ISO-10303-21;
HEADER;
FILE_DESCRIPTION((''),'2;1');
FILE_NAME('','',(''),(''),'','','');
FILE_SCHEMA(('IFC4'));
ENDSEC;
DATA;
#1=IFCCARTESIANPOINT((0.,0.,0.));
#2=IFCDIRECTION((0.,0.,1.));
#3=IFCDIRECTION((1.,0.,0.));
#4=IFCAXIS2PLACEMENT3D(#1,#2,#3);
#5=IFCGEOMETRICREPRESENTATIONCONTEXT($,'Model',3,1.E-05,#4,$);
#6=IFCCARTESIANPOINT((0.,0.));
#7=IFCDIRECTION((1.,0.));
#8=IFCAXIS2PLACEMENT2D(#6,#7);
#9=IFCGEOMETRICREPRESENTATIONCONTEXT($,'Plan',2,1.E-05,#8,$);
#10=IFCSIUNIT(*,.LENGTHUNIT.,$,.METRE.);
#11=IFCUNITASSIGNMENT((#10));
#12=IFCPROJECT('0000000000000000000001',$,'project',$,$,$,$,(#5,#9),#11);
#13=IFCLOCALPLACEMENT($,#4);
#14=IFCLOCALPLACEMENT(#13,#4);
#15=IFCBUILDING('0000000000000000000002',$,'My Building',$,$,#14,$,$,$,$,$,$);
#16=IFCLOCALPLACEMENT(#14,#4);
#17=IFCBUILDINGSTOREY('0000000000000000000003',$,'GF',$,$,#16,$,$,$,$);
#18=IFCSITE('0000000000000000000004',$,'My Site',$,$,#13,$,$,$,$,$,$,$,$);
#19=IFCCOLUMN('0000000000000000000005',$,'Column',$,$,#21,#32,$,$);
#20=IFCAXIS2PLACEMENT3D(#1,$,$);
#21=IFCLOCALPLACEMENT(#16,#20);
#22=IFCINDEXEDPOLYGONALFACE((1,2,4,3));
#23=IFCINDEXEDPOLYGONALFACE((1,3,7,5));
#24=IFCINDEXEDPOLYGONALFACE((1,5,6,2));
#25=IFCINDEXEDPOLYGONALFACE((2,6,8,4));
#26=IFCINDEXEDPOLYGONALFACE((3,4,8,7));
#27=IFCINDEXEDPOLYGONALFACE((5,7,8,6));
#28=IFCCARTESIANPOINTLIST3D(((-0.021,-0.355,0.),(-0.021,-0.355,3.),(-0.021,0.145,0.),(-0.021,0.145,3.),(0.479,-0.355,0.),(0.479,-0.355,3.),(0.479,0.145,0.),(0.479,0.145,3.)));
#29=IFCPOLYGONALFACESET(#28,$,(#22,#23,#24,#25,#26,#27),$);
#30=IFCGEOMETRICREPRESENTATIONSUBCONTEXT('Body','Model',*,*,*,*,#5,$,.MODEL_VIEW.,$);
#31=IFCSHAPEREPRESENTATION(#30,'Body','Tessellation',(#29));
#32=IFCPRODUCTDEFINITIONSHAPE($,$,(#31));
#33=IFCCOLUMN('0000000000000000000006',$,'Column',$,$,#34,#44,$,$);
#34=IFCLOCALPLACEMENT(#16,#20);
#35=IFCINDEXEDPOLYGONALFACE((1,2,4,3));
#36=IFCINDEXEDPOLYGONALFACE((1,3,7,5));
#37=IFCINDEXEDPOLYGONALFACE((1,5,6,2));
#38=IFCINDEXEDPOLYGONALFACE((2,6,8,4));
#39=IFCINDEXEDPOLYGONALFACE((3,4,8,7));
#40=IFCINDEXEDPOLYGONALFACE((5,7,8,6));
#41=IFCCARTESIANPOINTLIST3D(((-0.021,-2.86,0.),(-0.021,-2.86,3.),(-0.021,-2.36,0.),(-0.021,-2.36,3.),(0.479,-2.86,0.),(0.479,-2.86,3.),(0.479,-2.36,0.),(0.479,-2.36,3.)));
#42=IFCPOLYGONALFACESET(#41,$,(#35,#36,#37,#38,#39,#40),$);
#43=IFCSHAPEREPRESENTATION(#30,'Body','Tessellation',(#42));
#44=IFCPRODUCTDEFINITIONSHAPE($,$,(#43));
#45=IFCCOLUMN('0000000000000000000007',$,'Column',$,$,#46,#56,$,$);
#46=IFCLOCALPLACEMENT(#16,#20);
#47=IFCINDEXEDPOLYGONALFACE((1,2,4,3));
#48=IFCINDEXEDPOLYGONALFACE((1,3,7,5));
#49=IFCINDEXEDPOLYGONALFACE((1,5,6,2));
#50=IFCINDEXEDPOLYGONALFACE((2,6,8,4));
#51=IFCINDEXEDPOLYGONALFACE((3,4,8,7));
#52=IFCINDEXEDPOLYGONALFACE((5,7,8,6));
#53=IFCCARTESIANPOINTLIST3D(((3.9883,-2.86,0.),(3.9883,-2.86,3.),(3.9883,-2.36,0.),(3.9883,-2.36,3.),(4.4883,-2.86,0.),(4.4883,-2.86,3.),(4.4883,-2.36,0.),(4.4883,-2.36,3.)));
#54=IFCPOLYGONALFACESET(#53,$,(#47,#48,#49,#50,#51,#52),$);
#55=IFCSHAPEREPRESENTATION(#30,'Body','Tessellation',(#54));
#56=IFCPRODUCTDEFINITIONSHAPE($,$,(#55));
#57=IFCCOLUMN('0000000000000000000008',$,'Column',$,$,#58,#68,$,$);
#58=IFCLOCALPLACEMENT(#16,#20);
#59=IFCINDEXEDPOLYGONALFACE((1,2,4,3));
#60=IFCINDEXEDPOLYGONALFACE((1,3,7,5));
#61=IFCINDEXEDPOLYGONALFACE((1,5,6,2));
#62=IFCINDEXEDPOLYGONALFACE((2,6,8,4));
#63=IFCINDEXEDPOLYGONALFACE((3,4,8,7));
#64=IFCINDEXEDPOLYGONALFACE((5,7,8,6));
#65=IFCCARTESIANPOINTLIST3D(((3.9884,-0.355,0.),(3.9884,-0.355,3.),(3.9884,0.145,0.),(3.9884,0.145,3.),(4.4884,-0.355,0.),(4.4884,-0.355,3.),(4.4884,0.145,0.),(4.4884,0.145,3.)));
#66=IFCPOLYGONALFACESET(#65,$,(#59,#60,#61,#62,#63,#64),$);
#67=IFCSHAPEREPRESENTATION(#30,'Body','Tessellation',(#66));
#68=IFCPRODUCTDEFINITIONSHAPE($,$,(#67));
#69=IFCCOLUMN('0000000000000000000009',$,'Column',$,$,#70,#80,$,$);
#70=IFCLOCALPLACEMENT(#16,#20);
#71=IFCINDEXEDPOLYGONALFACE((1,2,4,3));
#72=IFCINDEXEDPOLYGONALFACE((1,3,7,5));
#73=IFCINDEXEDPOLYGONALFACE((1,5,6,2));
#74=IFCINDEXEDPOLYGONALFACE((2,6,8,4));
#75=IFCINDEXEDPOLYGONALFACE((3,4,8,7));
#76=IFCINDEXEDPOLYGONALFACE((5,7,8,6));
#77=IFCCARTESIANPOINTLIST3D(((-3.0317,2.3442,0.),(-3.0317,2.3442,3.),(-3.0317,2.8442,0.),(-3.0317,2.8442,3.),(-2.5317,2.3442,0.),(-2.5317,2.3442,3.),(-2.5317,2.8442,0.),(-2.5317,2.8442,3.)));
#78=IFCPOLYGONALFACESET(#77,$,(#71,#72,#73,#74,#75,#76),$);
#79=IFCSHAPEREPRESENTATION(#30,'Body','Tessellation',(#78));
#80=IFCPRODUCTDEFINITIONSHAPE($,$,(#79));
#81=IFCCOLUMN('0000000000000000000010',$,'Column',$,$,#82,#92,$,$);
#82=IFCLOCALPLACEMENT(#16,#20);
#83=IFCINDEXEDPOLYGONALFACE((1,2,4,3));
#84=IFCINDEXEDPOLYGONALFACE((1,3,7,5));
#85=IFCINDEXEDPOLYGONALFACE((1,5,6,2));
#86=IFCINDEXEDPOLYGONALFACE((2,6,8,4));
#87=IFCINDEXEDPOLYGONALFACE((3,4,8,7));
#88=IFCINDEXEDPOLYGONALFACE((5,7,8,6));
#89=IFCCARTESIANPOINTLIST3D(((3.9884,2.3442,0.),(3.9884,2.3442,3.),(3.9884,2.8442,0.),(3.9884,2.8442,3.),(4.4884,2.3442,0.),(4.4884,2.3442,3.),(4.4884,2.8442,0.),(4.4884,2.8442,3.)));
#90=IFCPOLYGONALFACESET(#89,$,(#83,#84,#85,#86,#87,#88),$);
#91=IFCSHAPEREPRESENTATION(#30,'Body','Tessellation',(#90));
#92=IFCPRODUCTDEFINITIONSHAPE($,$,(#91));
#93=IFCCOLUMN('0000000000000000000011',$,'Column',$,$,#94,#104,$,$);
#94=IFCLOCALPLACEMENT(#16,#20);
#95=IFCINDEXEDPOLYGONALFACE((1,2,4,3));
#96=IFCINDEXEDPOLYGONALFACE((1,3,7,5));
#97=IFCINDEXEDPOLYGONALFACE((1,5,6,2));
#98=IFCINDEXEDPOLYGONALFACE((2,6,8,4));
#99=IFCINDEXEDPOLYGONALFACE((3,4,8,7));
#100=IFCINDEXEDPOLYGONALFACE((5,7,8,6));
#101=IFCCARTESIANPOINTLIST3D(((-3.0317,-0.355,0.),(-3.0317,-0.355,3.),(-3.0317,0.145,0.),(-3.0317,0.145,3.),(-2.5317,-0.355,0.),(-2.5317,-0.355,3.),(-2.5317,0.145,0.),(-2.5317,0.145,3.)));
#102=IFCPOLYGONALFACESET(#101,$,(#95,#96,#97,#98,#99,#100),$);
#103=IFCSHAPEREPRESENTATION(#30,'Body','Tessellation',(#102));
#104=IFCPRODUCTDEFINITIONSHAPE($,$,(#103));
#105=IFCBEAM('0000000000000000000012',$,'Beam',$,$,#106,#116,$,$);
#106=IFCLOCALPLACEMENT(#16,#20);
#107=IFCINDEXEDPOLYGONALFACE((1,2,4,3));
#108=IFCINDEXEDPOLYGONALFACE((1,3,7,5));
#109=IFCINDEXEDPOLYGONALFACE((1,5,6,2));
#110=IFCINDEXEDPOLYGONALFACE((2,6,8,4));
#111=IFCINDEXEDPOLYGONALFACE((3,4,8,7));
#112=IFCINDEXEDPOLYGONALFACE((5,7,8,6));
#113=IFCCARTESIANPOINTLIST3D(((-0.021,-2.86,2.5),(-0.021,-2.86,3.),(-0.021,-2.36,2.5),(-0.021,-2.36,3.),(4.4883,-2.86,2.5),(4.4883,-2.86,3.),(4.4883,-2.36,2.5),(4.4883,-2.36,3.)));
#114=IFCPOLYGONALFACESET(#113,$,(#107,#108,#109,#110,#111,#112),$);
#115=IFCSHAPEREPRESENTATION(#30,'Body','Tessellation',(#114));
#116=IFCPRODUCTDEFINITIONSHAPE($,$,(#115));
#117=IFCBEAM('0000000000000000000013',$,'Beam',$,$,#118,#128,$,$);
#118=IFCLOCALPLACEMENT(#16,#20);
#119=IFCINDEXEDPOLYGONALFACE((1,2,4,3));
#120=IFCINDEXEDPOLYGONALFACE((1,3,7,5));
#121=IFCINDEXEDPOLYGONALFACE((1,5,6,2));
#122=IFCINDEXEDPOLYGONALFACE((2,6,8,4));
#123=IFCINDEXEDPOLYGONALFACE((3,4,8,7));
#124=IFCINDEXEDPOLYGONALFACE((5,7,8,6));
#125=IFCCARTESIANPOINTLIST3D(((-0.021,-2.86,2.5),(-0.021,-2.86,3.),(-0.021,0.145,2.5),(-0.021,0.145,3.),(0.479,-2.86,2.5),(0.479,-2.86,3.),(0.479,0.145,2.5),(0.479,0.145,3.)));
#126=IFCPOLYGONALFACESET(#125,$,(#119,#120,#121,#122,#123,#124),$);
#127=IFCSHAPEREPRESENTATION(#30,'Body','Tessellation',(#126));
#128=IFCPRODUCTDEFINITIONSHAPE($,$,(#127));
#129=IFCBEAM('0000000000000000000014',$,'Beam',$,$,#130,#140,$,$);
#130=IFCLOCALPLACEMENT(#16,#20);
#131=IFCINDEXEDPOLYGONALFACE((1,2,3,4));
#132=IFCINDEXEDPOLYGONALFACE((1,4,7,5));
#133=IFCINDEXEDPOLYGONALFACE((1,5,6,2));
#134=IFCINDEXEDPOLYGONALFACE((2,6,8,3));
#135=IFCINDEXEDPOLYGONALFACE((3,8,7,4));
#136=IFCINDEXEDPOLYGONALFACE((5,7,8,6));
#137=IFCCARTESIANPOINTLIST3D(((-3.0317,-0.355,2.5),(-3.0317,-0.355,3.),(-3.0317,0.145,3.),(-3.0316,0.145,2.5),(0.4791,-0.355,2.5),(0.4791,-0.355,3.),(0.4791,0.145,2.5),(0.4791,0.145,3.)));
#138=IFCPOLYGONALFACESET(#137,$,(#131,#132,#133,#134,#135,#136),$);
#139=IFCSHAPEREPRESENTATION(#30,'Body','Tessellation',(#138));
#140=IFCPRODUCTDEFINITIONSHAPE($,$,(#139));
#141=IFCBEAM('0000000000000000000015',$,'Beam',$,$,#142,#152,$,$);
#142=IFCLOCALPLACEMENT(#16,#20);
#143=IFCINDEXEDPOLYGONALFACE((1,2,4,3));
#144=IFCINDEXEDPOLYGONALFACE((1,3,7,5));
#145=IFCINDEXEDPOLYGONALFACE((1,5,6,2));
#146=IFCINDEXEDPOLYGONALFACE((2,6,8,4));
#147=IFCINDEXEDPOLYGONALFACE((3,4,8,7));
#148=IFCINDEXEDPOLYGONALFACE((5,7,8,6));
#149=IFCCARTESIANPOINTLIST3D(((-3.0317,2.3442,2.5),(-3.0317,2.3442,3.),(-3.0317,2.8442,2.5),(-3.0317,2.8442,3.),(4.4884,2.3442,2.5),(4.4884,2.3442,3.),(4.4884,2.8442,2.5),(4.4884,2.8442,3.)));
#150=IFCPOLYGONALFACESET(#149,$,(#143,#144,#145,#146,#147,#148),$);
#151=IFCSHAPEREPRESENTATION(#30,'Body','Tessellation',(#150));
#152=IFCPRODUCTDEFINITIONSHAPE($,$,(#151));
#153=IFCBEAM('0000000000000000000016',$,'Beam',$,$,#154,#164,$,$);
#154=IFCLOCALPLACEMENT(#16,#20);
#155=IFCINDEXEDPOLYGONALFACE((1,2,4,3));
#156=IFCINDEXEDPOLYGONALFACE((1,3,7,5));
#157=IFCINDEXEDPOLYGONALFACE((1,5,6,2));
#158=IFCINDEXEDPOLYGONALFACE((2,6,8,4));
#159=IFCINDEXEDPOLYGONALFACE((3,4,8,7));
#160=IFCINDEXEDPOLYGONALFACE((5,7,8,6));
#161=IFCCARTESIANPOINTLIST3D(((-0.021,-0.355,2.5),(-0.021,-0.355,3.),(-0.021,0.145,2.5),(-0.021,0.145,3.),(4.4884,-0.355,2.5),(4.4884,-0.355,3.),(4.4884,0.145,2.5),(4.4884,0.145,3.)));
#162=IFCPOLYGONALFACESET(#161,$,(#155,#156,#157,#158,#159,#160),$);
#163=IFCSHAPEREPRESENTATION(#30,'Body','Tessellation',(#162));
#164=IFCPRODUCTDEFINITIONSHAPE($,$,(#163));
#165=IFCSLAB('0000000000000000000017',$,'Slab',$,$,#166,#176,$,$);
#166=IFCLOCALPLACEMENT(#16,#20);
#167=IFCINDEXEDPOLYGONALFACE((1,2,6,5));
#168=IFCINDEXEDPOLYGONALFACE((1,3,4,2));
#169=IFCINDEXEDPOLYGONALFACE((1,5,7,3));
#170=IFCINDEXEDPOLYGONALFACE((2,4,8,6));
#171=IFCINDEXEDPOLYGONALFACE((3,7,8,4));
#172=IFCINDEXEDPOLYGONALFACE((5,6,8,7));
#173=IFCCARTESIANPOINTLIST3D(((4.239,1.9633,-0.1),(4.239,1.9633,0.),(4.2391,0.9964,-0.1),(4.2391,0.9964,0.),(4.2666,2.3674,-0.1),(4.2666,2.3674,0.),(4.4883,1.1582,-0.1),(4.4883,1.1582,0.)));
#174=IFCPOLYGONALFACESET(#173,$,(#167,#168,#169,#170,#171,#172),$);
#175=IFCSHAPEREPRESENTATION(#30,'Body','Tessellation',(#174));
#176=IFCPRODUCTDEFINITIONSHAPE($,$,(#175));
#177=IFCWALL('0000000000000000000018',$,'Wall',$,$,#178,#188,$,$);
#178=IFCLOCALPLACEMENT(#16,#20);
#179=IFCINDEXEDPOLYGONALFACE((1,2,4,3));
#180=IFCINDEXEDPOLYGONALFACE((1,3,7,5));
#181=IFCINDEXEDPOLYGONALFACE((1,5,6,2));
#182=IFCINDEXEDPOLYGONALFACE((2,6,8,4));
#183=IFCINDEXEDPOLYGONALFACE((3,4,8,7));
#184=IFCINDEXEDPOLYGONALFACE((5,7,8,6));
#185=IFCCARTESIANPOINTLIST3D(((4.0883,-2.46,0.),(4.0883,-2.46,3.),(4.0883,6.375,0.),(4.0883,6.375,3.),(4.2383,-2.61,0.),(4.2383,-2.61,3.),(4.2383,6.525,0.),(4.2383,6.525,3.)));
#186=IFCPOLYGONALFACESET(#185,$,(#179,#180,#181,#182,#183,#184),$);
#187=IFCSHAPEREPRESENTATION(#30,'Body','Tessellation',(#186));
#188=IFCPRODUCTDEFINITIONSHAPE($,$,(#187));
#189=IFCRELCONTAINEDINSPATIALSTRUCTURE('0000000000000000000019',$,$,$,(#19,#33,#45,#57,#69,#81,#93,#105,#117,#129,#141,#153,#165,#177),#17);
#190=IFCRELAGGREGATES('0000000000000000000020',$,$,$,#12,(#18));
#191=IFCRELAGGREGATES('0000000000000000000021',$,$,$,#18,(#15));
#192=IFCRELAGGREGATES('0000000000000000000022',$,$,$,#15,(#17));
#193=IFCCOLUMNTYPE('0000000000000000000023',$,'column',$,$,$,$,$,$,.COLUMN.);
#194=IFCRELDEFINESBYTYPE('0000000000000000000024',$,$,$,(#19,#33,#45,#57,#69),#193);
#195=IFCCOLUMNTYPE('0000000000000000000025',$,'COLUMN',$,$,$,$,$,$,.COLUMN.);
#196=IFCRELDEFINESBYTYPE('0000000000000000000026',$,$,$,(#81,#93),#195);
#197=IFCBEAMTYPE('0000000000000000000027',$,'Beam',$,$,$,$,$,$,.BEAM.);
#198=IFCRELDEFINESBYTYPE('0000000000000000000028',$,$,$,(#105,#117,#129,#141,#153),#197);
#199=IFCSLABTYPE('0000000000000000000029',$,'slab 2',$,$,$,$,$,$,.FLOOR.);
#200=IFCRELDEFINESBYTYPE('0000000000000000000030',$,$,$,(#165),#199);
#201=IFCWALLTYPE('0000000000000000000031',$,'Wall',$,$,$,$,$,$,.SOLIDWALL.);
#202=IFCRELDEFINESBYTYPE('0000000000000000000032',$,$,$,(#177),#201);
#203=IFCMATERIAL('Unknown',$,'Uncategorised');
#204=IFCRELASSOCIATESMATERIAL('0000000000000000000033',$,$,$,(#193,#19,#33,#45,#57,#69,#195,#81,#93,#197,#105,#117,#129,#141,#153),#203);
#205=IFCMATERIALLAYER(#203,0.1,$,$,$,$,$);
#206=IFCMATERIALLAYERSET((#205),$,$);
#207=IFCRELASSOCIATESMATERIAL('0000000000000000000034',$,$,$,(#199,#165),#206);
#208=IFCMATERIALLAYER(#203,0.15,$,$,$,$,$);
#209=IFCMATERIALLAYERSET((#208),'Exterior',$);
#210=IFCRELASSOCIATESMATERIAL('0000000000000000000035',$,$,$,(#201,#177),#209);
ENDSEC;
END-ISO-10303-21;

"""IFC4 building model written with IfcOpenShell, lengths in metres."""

from ifc_helpers import new_model, si_unit, frame, origin_with_axes, origin_2d_with_axis, place, context, subcontext, project, spatial, line, indexed_curve, rectangle, outline, extrude, material, layer, layer_set, layer_usage, material_profile, profile_set, profile_usage, type_object, element, save


model = new_model("IFC4")

# Units and contexts
model_context = context("Model", 3, precision=1e-05, world=origin_with_axes())
plan_context = context("Plan", 2, precision=1e-05, world=origin_2d_with_axis())
body_context_1 = subcontext(model_context, "Body", "Model", "MODEL_VIEW")
ifc_project = project(units=[si_unit("LENGTHUNIT", "METRE")], contexts=[model_context, plan_context])

# Site, building, storey
site_placement = place(None, origin_with_axes())
site = spatial("IfcSite", under=ifc_project, at=site_placement, Name="My Site")
building_placement = place(site_placement, origin_with_axes())
building = spatial("IfcBuilding", under=site, at=building_placement, Name="My Building")
storey_placement = place(building_placement, origin_with_axes())
storey = spatial("IfcBuildingStorey", under=building, at=storey_placement, Name="GF")

# Columns
ifc_material = material(Name="Unknown", Category="Uncategorised")
ifc_material_profile_1 = material_profile(ifc_material, rectangle(XDim=0.5, YDim=0.5))
ifc_profile_set_1 = profile_set([ifc_material_profile_1])
ifc_profile_usage_1 = profile_usage(ifc_profile_set_1, cardinal=5)
column_type_1 = type_object("IfcColumnType", Name="column", PredefinedType="COLUMN", material=ifc_profile_set_1)
column_1_placement = place(storey_placement, frame((0.229, -0.105, 0.0), z_axis=(0.0, 0.0, 1.0), x_axis=(1.0, 0.0, 0.0)))
element("IfcColumn", 1, at=column_1_placement, inside=storey, type_object=column_type_1, material=ifc_profile_usage_1, Name="Column", context=body_context_1, shape_type="SweptSolid", body=[
    extrude(rectangle(XDim=0.5, YDim=0.5), origin_with_axes(), (0.0, 0.0, 1.0), 3.0),
])
ifc_profile_usage_2 = profile_usage(ifc_profile_set_1, cardinal=5)
column_2_placement = place(storey_placement, frame((0.229, -2.61, 0.0), z_axis=(0.0, 0.0, 1.0), x_axis=(1.0, 0.0, 0.0)))
element("IfcColumn", 2, at=column_2_placement, inside=storey, type_object=column_type_1, material=ifc_profile_usage_2, Name="Column", context=body_context_1, shape_type="SweptSolid", body=[
    extrude(rectangle(XDim=0.5, YDim=0.5), origin_with_axes(), (0.0, 0.0, 1.0), 3.0),
])
ifc_profile_usage_3 = profile_usage(ifc_profile_set_1, cardinal=5)
column_3_placement = place(storey_placement, frame((4.2383, -2.61, 0.0), z_axis=(0.0, 0.0, 1.0), x_axis=(1.0, 0.0, 0.0)))
element("IfcColumn", 3, at=column_3_placement, inside=storey, type_object=column_type_1, material=ifc_profile_usage_3, Name="Column", context=body_context_1, shape_type="SweptSolid", body=[
    extrude(rectangle(XDim=0.5, YDim=0.5), origin_with_axes(), (0.0, 0.0, 1.0), 3.0),
])
ifc_profile_usage_4 = profile_usage(ifc_profile_set_1, cardinal=5)
column_4_placement = place(storey_placement, frame((4.2384, -0.105, 0.0), z_axis=(0.0, 0.0, 1.0), x_axis=(1.0, 0.0, 0.0)))
element("IfcColumn", 4, at=column_4_placement, inside=storey, type_object=column_type_1, material=ifc_profile_usage_4, Name="Column", context=body_context_1, shape_type="SweptSolid", body=[
    extrude(rectangle(XDim=0.5, YDim=0.5), origin_with_axes(), (0.0, 0.0, 1.0), 3.0),
])
ifc_profile_usage_5 = profile_usage(ifc_profile_set_1, cardinal=5)
column_5_placement = place(storey_placement, frame((-2.7817, 2.5942, 0.0), z_axis=(0.0, 0.0, 1.0), x_axis=(1.0, 0.0, 0.0)))
element("IfcColumn", 5, at=column_5_placement, inside=storey, type_object=column_type_1, material=ifc_profile_usage_5, Name="Column", context=body_context_1, shape_type="SweptSolid", body=[
    extrude(rectangle(XDim=0.5, YDim=0.5), origin_with_axes(), (0.0, 0.0, 1.0), 3.0),
])
ifc_material_profile_2 = material_profile(ifc_material, rectangle(XDim=0.5, YDim=0.5))
ifc_profile_set_2 = profile_set([ifc_material_profile_2])
ifc_profile_usage_6 = profile_usage(ifc_profile_set_2, cardinal=5)
column_type_2 = type_object("IfcColumnType", Name="COLUMN", PredefinedType="COLUMN", material=ifc_profile_set_2)
column_6_placement = place(storey_placement, frame((4.2384, 2.5942, 0.0), z_axis=(0.0, 0.0, 1.0), x_axis=(1.0, 0.0, 0.0)))
element("IfcColumn", 6, at=column_6_placement, inside=storey, type_object=column_type_2, material=ifc_profile_usage_6, Name="Column", context=body_context_1, shape_type="SweptSolid", body=[
    extrude(rectangle(XDim=0.5, YDim=0.5), origin_with_axes(), (0.0, 0.0, 1.0), 3.0),
])
ifc_profile_usage_7 = profile_usage(ifc_profile_set_2, cardinal=5)
column_7_placement = place(storey_placement, frame((-2.7817, -0.105, 0.0), z_axis=(0.0, 0.0, 1.0), x_axis=(1.0, 0.0, 0.0)))
element("IfcColumn", 7, at=column_7_placement, inside=storey, type_object=column_type_2, material=ifc_profile_usage_7, Name="Column", context=body_context_1, shape_type="SweptSolid", body=[
    extrude(rectangle(XDim=0.5, YDim=0.5), origin_with_axes(), (0.0, 0.0, 1.0), 3.0),
])

# Beams
ifc_material_profile_3 = material_profile(ifc_material, rectangle(XDim=0.5, YDim=0.5))
ifc_profile_set_3 = profile_set([ifc_material_profile_3])
ifc_profile_usage_8 = profile_usage(ifc_profile_set_3, cardinal=5)
beam_type = type_object("IfcBeamType", Name="Beam", PredefinedType="BEAM", material=ifc_profile_set_3)
beam_1_placement = place(storey_placement, frame((-0.021, -2.61, 2.75), z_axis=(1.0, 0.0, 0.000001), x_axis=(0.0, 1.0, 0.0)))
element("IfcBeam", 8, at=beam_1_placement, inside=storey, type_object=beam_type, material=ifc_profile_usage_8, Name="Beam", context=body_context_1, shape_type="SweptSolid", body=[
    extrude(rectangle(XDim=0.5, YDim=0.5), origin_with_axes(), (0.0, 0.0, 1.0), 4.5094),
])
ifc_profile_usage_9 = profile_usage(ifc_profile_set_3, cardinal=5)
beam_2_placement = place(storey_placement, frame((0.229, 0.145, 2.75), z_axis=(0.0, -1.0, 0.0), x_axis=(1.0, 0.0, 0.0)))
element("IfcBeam", 9, at=beam_2_placement, inside=storey, type_object=beam_type, material=ifc_profile_usage_9, Name="Beam", context=body_context_1, shape_type="SweptSolid", body=[
    extrude(rectangle(XDim=0.5, YDim=0.5), origin_with_axes(), (0.0, 0.0, 1.0), 3.005),
])
ifc_profile_usage_10 = profile_usage(ifc_profile_set_3, cardinal=5)
beam_3_placement = place(storey_placement, frame((-3.0317, -0.105, 2.75), z_axis=(1.0, 0.0, 0.0), x_axis=(0.0, 1.0, 0.0)))
element("IfcBeam", 10, at=beam_3_placement, inside=storey, type_object=beam_type, material=ifc_profile_usage_10, Name="Beam", context=body_context_1, shape_type="SweptSolid", body=[
    extrude(rectangle(XDim=0.5, YDim=0.5), origin_with_axes(), (0.0, 0.0, 1.0), 3.5107),
])
ifc_profile_usage_11 = profile_usage(ifc_profile_set_3, cardinal=5)
beam_4_placement = place(storey_placement, frame((-3.0317, 2.5942, 2.75), z_axis=(1.0, 0.0, 0.0), x_axis=(0.0, 1.0, 0.0)))
element("IfcBeam", 11, at=beam_4_placement, inside=storey, type_object=beam_type, material=ifc_profile_usage_11, Name="Beam", context=body_context_1, shape_type="SweptSolid", body=[
    extrude(rectangle(XDim=0.5, YDim=0.5), origin_with_axes(), (0.0, 0.0, 1.0), 7.52),
])
ifc_profile_usage_12 = profile_usage(ifc_profile_set_3, cardinal=5)
beam_5_placement = place(storey_placement, frame((-0.021, -0.105, 2.75), z_axis=(1.0, 0.0, 0.0), x_axis=(0.0, 1.0, 0.0)))
element("IfcBeam", 12, at=beam_5_placement, inside=storey, type_object=beam_type, material=ifc_profile_usage_12, Name="Beam", context=body_context_1, shape_type="SweptSolid", body=[
    extrude(rectangle(XDim=0.5, YDim=0.5), origin_with_axes(), (0.0, 0.0, 1.0), 4.5094),
])

# Slab
ifc_layer_1 = layer(ifc_material, 0.1)
ifc_layer_set_1 = layer_set([ifc_layer_1])
ifc_layer_usage_1 = layer_usage(ifc_layer_set_1, "AXIS3", "POSITIVE", -0.1)
slab_type_1 = type_object("IfcSlabType", Name="slab 2", PredefinedType="FLOOR", material=ifc_layer_set_1)
slab_1_placement = place(storey_placement, frame((4.2666, 2.3674, 0.0), z_axis=(0.0, 0.0, 1.0), x_axis=(1.0, 0.0, 0.0)))
element("IfcSlab", 13, at=slab_1_placement, inside=storey, type_object=slab_type_1, material=ifc_layer_usage_1, Name="Slab", context=body_context_1, shape_type="SweptSolid", body=[
    extrude(outline(indexed_curve([(0.0, 0.0), (0.2217, -1.2092), (-0.0275, -1.371), (-0.0276, -0.4041), (0.0, 0.0)])), frame((0.0, 0.0, -0.1), z_axis=(0.0, 0.0, 1.0), x_axis=(1.0, 0.0, 0.0)), (0.0, 0.0, 1.0), 0.1),
])

# Shared definitions
ifc_layer_2 = layer(ifc_material, 0.15)
ifc_layer_set_2 = layer_set([ifc_layer_2], Name="Exterior")
wall_type_1 = type_object("IfcWallType", Name="Wall", PredefinedType="SOLIDWALL", material=ifc_layer_set_2)

# Wall
ifc_layer_usage_2 = layer_usage(ifc_layer_set_2, "AXIS2", "POSITIVE", 0.0)
wall_1_placement = place(storey_placement, frame((4.2383, -2.61, 0.0), z_axis=(0.0, 0.0, 1.0), x_axis=(0.0, 1.0, 0.0)))
element("IfcWall", 14, at=wall_1_placement, inside=storey, type_object=wall_type_1, material=ifc_layer_usage_2, Name="Wall", context=body_context_1, shape_type="SweptSolid", body=[
    extrude(outline(indexed_curve([(0.0, 0.0), (0.15, 0.15), (8.985, 0.15), (9.135, 0.0)], segments=[line(1, 2, 3, 4, 1)])), origin_with_axes(), (0.0, 0.0, 1.0), 3.0),
])

save(model, "model.ifc")
